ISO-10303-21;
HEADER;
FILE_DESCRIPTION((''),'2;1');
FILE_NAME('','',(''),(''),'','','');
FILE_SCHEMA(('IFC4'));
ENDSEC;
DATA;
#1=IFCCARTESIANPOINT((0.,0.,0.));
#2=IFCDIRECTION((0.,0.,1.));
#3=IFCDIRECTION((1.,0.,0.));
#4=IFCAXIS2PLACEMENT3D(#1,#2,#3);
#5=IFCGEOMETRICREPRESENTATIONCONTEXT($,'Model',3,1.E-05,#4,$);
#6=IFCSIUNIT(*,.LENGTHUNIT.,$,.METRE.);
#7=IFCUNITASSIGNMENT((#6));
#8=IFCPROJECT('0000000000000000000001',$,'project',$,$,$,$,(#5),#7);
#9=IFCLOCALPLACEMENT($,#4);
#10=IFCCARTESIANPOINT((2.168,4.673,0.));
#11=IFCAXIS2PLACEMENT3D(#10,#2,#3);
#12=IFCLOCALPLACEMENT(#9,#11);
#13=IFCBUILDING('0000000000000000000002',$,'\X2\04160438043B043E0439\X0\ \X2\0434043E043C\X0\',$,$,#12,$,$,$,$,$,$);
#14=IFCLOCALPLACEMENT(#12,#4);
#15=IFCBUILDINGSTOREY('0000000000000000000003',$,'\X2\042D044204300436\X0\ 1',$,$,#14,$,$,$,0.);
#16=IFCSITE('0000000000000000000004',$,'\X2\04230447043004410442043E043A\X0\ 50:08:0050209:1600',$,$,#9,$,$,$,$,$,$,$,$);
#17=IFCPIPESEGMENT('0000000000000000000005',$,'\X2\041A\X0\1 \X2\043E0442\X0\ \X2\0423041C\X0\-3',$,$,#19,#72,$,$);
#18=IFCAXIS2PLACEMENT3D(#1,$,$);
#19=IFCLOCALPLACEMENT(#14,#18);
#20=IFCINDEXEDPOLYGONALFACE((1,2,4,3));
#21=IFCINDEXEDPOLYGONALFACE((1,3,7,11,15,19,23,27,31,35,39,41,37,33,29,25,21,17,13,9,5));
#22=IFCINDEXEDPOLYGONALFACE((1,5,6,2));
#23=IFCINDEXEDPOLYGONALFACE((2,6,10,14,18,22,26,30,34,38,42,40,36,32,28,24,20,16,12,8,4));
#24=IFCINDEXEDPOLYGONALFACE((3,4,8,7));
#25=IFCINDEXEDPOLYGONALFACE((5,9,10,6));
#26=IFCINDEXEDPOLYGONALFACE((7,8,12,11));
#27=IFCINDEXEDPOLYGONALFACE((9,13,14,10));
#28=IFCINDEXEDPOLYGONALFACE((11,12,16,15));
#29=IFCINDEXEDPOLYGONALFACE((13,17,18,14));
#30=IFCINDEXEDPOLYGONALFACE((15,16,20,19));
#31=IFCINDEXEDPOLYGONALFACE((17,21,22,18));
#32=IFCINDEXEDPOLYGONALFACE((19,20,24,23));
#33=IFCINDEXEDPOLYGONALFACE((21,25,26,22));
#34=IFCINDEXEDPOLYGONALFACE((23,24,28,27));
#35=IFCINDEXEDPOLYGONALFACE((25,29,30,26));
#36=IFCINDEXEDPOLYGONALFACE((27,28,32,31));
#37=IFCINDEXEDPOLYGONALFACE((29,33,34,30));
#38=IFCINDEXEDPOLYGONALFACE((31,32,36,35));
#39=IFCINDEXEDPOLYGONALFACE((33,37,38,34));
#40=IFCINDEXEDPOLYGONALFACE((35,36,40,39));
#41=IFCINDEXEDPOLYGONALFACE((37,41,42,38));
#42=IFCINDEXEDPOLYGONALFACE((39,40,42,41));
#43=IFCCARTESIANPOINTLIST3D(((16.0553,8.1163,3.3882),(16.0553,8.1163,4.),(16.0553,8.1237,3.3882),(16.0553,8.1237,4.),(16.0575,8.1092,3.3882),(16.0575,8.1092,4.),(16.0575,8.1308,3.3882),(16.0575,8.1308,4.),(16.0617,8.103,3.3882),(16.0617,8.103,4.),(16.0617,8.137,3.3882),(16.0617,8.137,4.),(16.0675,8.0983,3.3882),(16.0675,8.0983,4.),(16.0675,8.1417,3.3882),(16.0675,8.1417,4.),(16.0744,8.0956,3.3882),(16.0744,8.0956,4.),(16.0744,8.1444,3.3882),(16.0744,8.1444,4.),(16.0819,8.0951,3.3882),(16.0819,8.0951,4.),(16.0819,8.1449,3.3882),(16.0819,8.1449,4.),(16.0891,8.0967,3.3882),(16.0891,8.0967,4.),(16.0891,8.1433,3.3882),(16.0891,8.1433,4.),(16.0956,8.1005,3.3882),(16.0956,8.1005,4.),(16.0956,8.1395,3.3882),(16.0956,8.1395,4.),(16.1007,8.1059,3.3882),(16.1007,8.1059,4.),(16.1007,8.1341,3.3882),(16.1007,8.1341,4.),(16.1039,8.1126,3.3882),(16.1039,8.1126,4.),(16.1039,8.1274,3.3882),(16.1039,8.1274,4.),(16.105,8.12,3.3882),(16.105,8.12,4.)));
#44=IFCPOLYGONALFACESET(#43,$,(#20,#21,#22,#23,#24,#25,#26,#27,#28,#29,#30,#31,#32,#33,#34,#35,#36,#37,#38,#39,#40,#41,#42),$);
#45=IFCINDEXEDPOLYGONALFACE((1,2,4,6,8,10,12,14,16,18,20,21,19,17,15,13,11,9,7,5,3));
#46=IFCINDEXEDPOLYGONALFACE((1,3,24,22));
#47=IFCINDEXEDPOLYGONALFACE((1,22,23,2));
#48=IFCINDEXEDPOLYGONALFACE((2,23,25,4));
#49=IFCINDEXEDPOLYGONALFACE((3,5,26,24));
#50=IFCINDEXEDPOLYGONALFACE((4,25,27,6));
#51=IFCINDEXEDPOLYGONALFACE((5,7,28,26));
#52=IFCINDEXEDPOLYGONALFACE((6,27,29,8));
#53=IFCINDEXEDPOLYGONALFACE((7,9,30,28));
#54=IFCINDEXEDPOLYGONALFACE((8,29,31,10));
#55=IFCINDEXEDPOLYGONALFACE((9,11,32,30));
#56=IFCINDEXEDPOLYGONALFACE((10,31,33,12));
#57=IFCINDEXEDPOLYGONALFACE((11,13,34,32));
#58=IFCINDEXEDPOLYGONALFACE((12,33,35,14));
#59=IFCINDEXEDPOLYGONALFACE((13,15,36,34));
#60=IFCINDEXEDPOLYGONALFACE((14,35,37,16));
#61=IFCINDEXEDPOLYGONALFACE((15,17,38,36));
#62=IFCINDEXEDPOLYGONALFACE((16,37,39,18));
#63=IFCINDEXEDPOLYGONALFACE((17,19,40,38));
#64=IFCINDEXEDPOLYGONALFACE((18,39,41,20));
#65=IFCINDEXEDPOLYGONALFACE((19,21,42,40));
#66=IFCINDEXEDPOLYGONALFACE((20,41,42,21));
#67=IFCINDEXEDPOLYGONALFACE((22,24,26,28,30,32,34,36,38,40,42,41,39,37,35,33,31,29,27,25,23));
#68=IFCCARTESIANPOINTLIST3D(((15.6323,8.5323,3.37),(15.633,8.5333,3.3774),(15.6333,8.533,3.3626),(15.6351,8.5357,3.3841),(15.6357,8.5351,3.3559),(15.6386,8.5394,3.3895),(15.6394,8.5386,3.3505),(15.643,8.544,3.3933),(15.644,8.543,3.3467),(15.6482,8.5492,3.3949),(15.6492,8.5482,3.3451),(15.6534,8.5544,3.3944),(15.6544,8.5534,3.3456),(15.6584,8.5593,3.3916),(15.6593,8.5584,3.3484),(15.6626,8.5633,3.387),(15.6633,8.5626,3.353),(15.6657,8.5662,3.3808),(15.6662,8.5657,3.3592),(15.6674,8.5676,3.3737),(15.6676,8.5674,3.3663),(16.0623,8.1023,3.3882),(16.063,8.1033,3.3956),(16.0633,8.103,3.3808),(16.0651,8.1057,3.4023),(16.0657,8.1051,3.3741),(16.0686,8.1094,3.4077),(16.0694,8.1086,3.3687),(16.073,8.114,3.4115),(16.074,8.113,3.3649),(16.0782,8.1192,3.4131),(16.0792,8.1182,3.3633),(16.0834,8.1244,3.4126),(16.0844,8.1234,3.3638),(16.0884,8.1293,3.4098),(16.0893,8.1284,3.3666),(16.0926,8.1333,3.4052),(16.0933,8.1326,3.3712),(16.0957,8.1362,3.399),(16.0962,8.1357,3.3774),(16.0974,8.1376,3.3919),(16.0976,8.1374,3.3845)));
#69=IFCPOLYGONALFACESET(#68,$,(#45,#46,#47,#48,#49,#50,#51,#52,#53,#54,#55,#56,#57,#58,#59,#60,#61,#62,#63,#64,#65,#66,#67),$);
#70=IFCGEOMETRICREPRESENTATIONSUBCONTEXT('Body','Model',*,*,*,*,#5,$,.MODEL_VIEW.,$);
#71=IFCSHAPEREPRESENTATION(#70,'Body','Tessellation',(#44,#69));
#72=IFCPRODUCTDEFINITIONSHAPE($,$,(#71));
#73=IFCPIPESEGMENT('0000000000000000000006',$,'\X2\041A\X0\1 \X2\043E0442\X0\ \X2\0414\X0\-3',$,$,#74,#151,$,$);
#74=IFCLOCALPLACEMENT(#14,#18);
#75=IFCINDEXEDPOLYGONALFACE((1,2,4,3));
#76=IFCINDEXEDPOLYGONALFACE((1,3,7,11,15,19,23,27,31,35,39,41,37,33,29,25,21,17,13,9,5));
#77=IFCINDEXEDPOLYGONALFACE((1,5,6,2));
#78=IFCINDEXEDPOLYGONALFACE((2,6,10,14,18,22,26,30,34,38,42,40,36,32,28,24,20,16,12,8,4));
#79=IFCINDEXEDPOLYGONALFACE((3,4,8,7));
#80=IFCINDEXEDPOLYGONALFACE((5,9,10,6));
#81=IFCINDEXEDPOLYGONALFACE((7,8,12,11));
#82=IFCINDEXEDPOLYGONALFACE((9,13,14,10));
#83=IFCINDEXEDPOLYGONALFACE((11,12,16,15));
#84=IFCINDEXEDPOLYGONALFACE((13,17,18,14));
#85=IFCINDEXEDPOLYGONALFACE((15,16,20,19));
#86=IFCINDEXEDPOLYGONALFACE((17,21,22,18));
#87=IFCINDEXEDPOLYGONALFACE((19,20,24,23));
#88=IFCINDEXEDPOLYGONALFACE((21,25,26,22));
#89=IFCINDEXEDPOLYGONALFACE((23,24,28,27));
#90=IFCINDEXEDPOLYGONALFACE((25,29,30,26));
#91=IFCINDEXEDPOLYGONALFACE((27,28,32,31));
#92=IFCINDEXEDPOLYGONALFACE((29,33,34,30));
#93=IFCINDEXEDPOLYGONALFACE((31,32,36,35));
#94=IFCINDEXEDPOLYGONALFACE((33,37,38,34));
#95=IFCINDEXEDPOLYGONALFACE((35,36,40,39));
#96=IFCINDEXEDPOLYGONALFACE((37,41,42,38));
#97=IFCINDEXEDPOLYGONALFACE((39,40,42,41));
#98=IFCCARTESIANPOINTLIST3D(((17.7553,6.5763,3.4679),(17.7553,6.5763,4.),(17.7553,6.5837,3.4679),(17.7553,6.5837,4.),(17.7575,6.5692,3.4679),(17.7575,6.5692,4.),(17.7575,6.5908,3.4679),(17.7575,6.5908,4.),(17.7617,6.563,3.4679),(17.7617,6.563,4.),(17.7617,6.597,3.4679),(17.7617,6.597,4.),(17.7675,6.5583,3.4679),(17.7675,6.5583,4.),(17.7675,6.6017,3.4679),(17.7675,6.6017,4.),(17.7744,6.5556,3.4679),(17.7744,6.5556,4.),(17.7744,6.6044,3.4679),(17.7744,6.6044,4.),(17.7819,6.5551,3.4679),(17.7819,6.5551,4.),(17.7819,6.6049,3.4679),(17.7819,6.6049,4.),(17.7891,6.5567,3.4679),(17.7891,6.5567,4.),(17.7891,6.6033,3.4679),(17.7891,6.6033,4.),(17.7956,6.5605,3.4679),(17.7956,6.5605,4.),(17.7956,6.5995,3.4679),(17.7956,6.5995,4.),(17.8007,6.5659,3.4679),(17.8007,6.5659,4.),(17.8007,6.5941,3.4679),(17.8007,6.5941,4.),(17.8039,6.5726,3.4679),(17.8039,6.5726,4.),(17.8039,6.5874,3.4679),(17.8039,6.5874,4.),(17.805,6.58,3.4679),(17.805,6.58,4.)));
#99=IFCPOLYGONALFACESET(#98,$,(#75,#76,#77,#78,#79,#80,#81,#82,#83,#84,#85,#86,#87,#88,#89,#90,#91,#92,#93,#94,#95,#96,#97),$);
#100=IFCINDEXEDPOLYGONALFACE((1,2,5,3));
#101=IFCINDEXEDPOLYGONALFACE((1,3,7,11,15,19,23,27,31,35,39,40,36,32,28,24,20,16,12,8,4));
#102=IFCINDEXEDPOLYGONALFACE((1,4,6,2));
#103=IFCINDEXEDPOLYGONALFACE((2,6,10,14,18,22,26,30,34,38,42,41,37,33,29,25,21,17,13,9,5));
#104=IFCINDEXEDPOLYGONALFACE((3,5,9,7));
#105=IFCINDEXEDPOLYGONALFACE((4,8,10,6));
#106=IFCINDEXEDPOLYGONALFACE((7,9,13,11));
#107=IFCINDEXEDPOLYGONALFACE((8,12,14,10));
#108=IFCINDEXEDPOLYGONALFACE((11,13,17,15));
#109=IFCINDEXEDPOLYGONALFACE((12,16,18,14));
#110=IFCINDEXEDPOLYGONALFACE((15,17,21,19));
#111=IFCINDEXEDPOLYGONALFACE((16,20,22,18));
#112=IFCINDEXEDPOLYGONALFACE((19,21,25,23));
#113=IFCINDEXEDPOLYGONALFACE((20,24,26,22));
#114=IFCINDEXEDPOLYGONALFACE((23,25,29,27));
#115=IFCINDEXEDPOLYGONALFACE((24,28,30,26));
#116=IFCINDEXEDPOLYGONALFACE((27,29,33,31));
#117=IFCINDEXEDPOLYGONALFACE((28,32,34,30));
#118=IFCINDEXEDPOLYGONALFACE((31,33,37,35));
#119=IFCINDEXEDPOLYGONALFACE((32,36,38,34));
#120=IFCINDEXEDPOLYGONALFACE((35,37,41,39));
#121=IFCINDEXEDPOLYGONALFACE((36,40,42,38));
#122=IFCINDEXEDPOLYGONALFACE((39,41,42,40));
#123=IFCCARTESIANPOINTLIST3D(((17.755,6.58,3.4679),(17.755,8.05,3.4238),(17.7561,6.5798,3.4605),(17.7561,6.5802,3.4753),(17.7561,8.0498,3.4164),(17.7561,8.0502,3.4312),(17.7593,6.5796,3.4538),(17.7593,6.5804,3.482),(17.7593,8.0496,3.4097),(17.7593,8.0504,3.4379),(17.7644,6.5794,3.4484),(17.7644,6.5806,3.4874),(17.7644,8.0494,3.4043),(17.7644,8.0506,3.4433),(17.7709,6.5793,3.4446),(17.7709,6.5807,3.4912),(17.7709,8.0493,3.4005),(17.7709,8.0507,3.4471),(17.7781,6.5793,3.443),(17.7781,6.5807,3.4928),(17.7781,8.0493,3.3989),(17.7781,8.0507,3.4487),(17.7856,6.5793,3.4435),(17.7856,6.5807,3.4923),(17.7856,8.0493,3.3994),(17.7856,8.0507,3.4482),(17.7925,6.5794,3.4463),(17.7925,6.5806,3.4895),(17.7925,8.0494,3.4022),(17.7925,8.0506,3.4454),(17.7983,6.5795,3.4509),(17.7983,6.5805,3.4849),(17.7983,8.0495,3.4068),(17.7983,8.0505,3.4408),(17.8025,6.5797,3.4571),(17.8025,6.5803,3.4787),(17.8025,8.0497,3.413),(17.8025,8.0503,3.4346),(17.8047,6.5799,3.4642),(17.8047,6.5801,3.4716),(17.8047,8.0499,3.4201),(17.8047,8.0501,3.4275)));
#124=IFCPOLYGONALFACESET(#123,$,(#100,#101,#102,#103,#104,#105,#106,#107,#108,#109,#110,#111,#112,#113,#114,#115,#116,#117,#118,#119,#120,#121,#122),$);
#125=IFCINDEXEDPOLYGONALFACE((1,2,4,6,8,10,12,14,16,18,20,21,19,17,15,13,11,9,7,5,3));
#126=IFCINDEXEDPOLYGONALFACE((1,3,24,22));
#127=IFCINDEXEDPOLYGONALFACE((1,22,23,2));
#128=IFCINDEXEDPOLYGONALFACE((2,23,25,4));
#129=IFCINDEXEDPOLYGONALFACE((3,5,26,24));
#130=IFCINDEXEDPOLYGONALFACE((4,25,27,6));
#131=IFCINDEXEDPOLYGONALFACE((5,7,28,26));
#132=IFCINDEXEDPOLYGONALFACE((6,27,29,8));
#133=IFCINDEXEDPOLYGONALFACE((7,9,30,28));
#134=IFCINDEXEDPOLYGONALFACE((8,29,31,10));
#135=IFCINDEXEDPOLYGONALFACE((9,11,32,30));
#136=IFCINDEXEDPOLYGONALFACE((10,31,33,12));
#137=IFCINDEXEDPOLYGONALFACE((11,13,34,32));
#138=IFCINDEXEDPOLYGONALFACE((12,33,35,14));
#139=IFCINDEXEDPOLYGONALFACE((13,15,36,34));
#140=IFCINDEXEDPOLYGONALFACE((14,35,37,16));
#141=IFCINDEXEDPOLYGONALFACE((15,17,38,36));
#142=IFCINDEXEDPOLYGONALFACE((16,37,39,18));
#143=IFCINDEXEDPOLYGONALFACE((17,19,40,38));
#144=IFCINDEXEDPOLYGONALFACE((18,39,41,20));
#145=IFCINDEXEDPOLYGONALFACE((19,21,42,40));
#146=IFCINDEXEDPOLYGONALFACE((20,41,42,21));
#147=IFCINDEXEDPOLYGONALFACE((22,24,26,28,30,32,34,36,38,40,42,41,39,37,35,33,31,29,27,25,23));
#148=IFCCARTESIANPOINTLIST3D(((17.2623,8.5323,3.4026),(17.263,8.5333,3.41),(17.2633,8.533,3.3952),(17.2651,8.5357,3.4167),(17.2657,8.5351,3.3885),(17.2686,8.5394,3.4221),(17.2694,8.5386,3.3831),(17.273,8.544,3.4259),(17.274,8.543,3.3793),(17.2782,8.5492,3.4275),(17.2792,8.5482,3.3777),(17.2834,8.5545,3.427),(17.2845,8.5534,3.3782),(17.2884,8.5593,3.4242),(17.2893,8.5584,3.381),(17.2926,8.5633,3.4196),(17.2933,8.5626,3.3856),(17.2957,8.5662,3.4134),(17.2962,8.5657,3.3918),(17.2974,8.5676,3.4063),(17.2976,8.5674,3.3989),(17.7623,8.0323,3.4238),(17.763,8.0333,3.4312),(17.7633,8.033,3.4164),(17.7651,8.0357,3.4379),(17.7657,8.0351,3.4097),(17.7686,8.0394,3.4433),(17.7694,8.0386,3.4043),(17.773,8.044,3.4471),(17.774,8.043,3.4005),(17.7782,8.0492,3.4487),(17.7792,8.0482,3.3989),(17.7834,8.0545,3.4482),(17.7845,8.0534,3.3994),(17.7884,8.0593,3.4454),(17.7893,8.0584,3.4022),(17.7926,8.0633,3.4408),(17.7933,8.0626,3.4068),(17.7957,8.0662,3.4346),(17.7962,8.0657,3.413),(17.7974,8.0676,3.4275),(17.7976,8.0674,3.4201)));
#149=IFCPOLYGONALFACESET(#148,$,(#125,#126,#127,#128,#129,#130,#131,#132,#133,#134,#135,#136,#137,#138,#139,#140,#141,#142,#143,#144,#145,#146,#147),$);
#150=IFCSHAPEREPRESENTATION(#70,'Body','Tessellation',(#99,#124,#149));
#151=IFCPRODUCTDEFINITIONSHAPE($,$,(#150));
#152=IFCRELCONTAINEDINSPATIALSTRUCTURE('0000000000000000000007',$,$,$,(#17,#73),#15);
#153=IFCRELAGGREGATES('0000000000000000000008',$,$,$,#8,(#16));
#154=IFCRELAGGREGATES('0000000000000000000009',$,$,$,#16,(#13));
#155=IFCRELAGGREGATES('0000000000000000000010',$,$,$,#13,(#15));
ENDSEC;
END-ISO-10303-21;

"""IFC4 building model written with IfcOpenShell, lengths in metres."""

from ifc_helpers import new_model, si_unit, frame, origin_with_axes, origin_2d, place, context, subcontext, project, spatial, circle, extrude, element, save


model = new_model("IFC4")

# Units and contexts
model_context = context("Model", 3, precision=1e-05, world=origin_with_axes())
body_context = subcontext(model_context, "Body", "Model", "MODEL_VIEW")
ifc_project = project(units=[si_unit("LENGTHUNIT", "METRE")], contexts=[model_context])

# Site, building, storey
site_placement = place(None, origin_with_axes())
site = spatial("IfcSite", under=ifc_project, at=site_placement, Name="Участок 50:08:0050209:1600")
building_placement = place(site_placement, frame((2.168, 4.673, 0.0), z_axis=(0.0, 0.0, 1.0), x_axis=(1.0, 0.0, 0.0)))
building = spatial("IfcBuilding", under=site, at=building_placement, Name="Жилой дом")
storey_placement = place(building_placement, origin_with_axes())
storey = spatial("IfcBuildingStorey", under=building, at=storey_placement, Name="Этаж 1", Elevation=0.0)

# Pipe segments
pipe_segment_1_placement = place(storey_placement, origin_with_axes())
element("IfcPipeSegment", 1, at=pipe_segment_1_placement, inside=storey, Name="К1 от УМ-3", context=body_context, shape_type="SweptSolid", body=[
    extrude(circle(Radius=0.025, at=origin_2d()), frame((16.08, 8.12, 4.0), z_axis=(0.0, 0.0, -1.0), x_axis=(1.0, 0.0, 0.0)), (0.0, 0.0, 1.0), 0.6118),
    extrude(circle(Radius=0.025, at=origin_2d()), frame((16.08, 8.12, 3.3882), z_axis=(-0.70679, 0.70679, -0.029915), x_axis=(-0.707107, -0.707107, 0.0)), (0.0, 0.0, 1.0), 0.6084),
])
pipe_segment_2_placement = place(storey_placement, origin_with_axes())
element("IfcPipeSegment", 2, at=pipe_segment_2_placement, inside=storey, Name="К1 от Д-3", context=body_context, shape_type="SweptSolid", body=[
    extrude(circle(Radius=0.025, at=origin_2d()), frame((17.78, 6.58, 4.0), z_axis=(0.0, 0.0, -1.0), x_axis=(1.0, 0.0, 0.0)), (0.0, 0.0, 1.0), 0.5321),
    extrude(circle(Radius=0.025, at=origin_2d()), frame((17.78, 6.58, 3.4679), z_axis=(0.0, 0.99955, -0.029987), x_axis=(-1.0, 0.0, 0.0)), (0.0, 0.0, 1.0), 1.4707),
    extrude(circle(Radius=0.025, at=origin_2d()), frame((17.78, 8.05, 3.4238), z_axis=(-0.706789, 0.706789, -0.029968), x_axis=(-0.707107, -0.707107, 0.0)), (0.0, 0.0, 1.0), 0.7074),
])

save(model, "model.ifc")
